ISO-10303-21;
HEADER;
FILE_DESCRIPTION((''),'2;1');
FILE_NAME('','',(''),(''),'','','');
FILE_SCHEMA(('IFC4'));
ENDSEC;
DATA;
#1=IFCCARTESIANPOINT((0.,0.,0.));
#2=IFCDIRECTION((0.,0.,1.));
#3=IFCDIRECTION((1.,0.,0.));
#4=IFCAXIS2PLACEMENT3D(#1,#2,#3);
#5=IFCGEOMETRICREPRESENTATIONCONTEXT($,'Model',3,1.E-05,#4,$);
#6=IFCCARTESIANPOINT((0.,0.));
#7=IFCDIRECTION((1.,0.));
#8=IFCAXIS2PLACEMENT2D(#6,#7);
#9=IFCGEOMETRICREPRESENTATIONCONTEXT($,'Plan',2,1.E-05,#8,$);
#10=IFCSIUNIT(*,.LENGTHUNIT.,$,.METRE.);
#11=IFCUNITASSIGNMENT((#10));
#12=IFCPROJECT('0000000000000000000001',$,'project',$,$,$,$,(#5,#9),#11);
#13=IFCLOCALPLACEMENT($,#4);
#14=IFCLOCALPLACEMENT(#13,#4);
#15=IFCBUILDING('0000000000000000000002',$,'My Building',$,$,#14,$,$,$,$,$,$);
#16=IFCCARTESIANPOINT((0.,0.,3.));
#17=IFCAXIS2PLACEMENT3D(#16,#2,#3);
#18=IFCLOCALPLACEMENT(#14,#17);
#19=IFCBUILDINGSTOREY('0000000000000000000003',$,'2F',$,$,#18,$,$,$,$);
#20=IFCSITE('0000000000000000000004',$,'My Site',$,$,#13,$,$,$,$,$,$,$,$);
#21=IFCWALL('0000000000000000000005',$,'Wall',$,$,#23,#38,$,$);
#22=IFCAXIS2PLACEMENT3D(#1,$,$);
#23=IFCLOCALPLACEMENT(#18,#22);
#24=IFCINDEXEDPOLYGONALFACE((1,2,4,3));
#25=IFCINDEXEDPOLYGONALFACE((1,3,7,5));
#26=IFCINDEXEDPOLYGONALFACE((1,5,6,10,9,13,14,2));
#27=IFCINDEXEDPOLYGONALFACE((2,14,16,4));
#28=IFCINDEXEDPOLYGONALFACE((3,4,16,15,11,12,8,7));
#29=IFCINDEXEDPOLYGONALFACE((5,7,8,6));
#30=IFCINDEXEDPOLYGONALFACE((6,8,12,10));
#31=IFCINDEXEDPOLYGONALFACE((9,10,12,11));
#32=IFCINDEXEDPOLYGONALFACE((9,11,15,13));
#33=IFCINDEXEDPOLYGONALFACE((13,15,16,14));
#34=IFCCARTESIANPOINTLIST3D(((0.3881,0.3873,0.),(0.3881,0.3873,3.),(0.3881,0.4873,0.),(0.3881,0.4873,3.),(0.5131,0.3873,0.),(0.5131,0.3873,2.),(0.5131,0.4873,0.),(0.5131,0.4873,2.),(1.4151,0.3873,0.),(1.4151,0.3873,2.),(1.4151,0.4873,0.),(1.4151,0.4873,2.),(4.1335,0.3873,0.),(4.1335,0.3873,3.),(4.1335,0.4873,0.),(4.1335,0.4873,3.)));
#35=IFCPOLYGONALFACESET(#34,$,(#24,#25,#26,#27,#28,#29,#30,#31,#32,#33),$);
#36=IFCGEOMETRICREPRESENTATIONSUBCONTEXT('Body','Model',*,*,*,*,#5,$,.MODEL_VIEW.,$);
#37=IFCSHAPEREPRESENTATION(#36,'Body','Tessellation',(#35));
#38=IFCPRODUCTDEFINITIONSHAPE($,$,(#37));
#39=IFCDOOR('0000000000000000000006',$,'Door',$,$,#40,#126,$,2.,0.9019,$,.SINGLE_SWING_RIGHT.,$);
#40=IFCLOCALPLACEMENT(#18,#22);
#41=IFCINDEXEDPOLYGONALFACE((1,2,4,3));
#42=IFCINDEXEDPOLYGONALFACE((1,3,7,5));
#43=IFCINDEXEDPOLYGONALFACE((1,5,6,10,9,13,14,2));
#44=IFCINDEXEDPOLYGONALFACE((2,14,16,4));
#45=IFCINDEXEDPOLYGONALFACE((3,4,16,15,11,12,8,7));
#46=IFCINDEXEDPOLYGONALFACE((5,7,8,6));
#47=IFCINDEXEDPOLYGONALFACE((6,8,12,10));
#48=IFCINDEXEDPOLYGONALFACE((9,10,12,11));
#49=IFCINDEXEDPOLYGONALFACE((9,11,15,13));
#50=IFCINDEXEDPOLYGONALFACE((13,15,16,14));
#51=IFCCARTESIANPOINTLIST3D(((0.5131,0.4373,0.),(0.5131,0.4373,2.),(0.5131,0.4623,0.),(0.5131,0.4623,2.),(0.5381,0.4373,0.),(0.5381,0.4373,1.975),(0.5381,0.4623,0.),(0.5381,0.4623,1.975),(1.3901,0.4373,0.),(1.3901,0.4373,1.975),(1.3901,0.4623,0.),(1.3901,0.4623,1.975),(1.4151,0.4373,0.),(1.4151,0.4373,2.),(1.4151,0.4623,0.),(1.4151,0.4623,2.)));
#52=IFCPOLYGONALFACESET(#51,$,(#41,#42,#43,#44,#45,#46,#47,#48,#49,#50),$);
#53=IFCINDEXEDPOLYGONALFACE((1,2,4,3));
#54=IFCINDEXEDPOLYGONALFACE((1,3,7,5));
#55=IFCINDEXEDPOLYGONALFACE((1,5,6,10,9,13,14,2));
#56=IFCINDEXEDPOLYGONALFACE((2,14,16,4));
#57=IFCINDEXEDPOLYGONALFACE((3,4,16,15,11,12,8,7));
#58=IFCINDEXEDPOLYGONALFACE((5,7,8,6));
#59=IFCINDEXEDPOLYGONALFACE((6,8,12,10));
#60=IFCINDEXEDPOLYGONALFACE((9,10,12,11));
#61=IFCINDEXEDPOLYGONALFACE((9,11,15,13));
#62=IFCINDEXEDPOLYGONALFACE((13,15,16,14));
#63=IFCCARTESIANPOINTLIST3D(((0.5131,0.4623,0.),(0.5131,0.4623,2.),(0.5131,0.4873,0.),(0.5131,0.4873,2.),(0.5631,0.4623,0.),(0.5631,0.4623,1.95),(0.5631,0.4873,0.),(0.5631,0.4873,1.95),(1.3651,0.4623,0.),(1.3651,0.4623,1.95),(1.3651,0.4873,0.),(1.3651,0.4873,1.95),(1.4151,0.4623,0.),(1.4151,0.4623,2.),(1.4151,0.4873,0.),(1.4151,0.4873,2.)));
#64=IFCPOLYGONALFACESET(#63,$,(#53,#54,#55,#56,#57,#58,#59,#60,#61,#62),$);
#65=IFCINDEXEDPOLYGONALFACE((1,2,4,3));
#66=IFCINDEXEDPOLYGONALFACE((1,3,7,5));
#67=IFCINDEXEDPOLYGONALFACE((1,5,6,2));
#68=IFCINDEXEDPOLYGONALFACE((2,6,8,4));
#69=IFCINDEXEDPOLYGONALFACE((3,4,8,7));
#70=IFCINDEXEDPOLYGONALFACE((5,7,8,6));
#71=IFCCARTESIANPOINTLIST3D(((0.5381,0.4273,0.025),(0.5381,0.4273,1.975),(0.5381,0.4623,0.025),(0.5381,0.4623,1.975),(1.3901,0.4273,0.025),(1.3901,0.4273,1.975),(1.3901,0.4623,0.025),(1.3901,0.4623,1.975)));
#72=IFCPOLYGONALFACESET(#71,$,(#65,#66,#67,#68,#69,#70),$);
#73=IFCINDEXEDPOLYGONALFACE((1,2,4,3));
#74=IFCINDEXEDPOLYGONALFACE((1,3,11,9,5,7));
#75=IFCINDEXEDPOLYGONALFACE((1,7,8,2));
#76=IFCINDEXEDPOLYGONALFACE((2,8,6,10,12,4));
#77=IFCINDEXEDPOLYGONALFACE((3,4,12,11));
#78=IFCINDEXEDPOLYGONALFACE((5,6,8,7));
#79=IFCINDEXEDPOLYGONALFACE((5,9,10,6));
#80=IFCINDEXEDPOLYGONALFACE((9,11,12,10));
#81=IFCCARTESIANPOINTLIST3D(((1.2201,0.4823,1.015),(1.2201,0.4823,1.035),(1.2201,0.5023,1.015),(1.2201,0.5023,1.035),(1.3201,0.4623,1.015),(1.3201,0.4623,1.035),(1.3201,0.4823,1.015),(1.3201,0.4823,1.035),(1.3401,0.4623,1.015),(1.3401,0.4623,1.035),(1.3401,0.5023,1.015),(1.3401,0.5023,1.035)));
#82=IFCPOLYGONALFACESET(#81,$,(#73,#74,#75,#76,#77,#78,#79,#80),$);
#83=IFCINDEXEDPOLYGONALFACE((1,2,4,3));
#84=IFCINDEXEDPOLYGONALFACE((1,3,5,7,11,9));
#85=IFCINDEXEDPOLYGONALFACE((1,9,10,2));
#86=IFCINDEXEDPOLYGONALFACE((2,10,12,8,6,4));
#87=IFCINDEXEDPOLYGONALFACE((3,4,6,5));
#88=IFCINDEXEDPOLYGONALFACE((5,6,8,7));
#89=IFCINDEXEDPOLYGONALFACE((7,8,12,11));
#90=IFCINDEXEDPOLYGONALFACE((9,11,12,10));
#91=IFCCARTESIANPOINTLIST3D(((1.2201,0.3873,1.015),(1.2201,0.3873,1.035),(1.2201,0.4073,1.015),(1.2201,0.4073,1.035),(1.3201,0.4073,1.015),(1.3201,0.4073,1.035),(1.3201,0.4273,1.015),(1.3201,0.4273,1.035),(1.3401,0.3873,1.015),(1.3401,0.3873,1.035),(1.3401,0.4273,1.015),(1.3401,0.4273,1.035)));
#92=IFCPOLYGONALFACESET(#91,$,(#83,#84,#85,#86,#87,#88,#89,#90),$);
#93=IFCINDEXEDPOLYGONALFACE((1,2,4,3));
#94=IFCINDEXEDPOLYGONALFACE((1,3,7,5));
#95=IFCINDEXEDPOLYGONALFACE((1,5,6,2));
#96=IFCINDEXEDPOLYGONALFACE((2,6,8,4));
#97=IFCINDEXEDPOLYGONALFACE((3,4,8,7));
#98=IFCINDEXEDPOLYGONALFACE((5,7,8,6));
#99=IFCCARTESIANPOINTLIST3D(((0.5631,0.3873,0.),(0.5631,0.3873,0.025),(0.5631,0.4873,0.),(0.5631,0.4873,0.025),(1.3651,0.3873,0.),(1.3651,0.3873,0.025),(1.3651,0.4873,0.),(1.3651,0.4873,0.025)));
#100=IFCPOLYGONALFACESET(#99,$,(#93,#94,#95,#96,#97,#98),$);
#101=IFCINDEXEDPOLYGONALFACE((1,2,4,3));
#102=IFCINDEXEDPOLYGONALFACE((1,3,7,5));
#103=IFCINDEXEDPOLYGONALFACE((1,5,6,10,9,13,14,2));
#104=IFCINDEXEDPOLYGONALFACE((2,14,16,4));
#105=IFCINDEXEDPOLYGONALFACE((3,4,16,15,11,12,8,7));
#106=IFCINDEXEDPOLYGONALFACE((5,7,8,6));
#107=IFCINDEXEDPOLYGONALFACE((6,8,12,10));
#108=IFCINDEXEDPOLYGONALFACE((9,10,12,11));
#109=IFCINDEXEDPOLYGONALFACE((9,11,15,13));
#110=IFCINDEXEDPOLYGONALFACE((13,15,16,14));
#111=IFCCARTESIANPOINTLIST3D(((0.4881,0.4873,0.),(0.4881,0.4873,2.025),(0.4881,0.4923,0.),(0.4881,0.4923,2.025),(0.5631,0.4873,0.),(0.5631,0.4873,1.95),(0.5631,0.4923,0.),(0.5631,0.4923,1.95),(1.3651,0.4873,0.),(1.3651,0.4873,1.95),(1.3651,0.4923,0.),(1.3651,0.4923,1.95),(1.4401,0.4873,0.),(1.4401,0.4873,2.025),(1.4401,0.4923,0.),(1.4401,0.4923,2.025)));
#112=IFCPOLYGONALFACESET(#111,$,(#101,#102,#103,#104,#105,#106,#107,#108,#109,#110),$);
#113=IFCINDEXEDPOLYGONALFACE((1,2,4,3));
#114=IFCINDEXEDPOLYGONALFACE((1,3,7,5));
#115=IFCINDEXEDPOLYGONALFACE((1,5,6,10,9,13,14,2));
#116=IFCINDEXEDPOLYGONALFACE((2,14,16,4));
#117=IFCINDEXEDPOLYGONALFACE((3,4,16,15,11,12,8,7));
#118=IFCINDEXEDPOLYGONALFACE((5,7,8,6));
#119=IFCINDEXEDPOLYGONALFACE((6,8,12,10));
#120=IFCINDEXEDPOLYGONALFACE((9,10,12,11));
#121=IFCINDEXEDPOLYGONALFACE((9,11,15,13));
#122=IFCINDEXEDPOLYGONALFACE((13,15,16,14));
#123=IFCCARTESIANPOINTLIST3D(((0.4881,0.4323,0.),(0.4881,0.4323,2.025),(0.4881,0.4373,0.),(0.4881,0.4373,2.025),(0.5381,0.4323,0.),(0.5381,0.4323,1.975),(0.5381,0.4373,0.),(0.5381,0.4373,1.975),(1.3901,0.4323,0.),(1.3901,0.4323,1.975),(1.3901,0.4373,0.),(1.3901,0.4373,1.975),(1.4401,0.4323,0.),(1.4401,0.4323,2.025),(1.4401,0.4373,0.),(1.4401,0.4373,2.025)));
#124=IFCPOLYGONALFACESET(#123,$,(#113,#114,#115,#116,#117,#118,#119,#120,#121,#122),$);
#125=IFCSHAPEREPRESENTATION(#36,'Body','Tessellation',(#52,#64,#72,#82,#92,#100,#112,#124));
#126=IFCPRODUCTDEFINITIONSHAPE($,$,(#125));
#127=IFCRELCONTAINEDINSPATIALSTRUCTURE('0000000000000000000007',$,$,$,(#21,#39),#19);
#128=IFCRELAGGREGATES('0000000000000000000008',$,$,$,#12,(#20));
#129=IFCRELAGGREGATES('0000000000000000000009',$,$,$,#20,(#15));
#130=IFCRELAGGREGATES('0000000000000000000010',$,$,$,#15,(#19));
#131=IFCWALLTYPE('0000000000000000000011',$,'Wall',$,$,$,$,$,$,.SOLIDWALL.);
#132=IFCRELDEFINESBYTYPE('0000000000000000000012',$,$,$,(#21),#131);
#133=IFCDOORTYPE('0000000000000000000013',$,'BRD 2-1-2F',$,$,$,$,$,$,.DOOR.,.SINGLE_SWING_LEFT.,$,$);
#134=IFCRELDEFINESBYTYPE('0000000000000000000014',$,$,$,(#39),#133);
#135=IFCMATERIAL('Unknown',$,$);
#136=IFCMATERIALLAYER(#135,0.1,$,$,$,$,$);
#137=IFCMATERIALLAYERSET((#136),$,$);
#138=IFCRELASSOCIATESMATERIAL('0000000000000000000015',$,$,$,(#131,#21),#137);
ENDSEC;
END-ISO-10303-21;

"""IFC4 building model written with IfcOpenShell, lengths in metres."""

from ifc_helpers import new_model, entity, si_unit, frame, origin_with_axes, origin_2d_with_axis, place, context, subcontext, project, spatial, line, indexed_curve, outline, extrude, shape, source, transform, mapped, material, layer, layer_set, layer_usage, type_object, type_shapes, element, fill, save


model = new_model("IFC4")

# Units and contexts
model_context = context("Model", 3, precision=1e-05, world=origin_with_axes())
plan_context = context("Plan", 2, precision=1e-05, world=origin_2d_with_axis())
body_context_1 = subcontext(model_context, "Body", "Model", "MODEL_VIEW")
body_context_2 = subcontext(plan_context, "Body", "Plan", "PLAN_VIEW")
ifc_project = project(units=[si_unit("LENGTHUNIT", "METRE")], contexts=[model_context, plan_context])

# Site, building, storey
site_placement = place(None, origin_with_axes())
site = spatial("IfcSite", under=ifc_project, at=site_placement, Name="My Site")
building_placement = place(site_placement, origin_with_axes())
building = spatial("IfcBuilding", under=site, at=building_placement, Name="My Building")
storey_placement = place(building_placement, frame((0.0, 0.0, 3.0), z_axis=(0.0, 0.0, 1.0), x_axis=(1.0, 0.0, 0.0)))
storey = spatial("IfcBuildingStorey", under=building, at=storey_placement, Name="2F")

# Shared definitions
ifc_material = material(Name="Unknown")
ifc_layer = layer(ifc_material, 0.1)
ifc_layer_set = layer_set([ifc_layer])
wall_type = type_object("IfcWallType", Name="Wall", PredefinedType="SOLIDWALL", material=ifc_layer_set)

# Wall, opening, door
ifc_layer_usage_1 = layer_usage(ifc_layer_set, "AXIS2", "POSITIVE", 0.0)
wall_1_placement = place(storey_placement, frame((0.3881, 0.3873, 0.0), z_axis=(0.0, 0.0, 1.0), x_axis=(1.0, 0.0, 0.0)))
wall_1 = element("IfcWall", 1, at=wall_1_placement, inside=storey, type_object=wall_type, material=ifc_layer_usage_1, Name="Wall", context=body_context_1, shape_type="SweptSolid", body=[
    extrude(outline(indexed_curve([(0.0, 0.0), (0.0, 0.1), (3.7454, 0.1), (3.7454, 0.0)], segments=[line(1, 2, 3, 4, 1)])), origin_with_axes(), (0.0, 0.0, 1.0), 3.0),
])
shared_shape_1 = source(origin_with_axes(), body_context_1, "Body", "SweptSolid", [
    extrude(outline(indexed_curve([(0.0, 0.0), (0.9019, 0.0), (0.9019, 2.0), (0.0, 2.0)], segments=[line(1, 2, 3, 4, 1)])), frame((0.0, -0.6, 0.0), z_axis=(0.0, -1.0, 0.0), x_axis=(1.0, 0.0, 0.0)), (0.0, 0.0, -1.0), 1.2),
])
opening_1_placement = place(wall_1_placement, frame((1.0269, 0.1, 0.0), z_axis=(0.0, 0.0, 1.0), x_axis=(-1.0, 0.000001, 0.0)))
opening_1 = element("IfcOpeningElement", 2, at=opening_1_placement, cuts=wall_1, PredefinedType="OPENING", context=body_context_1, shape_type="MappedRepresentation", body=[
    mapped(shared_shape_1, transform((0.0, 0.0, 0.0), x_axis=(1.0, 0.0, 0.0), y_axis=(0.0, 1.0, 0.0), z_axis=(0.0, 0.0, 1.0), scale=1.0)),
])
door_type_1 = type_object("IfcDoorType", Name="BRD 2-1-2F", OperationType="SINGLE_SWING_LEFT", PredefinedType="DOOR")
shared_shape_2 = source(origin_with_axes(), body_context_1, "Body", "SweptSolid", [
    extrude(outline(indexed_curve([(0.0, 0.0), (0.0, 2.0), (0.9019, 2.0), (0.9019, 0.0), (0.8769, 0.0), (0.8769, 1.975), (0.025, 1.975), (0.025, 0.0)], segments=[line(1, 2, 3, 4, 5, 6, 7, 8, 1)])), frame((0.0, 0.025, 0.0), z_axis=(0.0, -1.0, 0.0), x_axis=(1.0, 0.0, 0.0)), (0.0, 0.0, -1.0), 0.025),
    extrude(outline(indexed_curve([(0.0, 0.0), (0.0, 2.0), (0.9019, 2.0), (0.9019, 0.0), (0.8519, 0.0), (0.8519, 1.95), (0.05, 1.95), (0.05, 0.0)], segments=[line(1, 2, 3, 4, 5, 6, 7, 8, 1)])), frame((0.0, 0.0, 0.0), z_axis=(0.0, -1.0, 0.0), x_axis=(1.0, 0.0, 0.0)), (0.0, 0.0, -1.0), 0.025),
    extrude(outline(indexed_curve([(0.0, 0.0), (0.8519, 0.0), (0.8519, 0.035), (0.0, 0.035)], segments=[line(1, 2, 3, 4, 1)])), frame((0.025, 0.025, 0.025), z_axis=(0.0, 0.0, 1.0), x_axis=(1.0, 0.0, 0.0)), (0.0, 0.0, 1.0), 1.95),
    extrude(outline(indexed_curve([(0.0, 0.0), (0.0, -0.04), (0.12, -0.04), (0.12, -0.02), (0.02, -0.02), (0.02, 0.0)], segments=[line(1, 2, 3, 4, 5, 6, 1)])), frame((0.075, 0.025, 1.015), z_axis=(0.0, 0.0, 1.0), x_axis=(1.0, 0.0, 0.0)), (0.0, 0.0, 1.0), 0.02),
    extrude(outline(indexed_curve([(0.0, 0.0), (0.0, 0.04), (0.12, 0.04), (0.12, 0.02), (0.02, 0.02), (0.02, 0.0)], segments=[line(1, 2, 3, 4, 5, 6, 1)])), frame((0.075, 0.06, 1.015), z_axis=(0.0, 0.0, 1.0), x_axis=(1.0, 0.0, 0.0)), (0.0, 0.0, 1.0), 0.02),
    extrude(outline(indexed_curve([(0.0, 0.0), (0.8019, 0.0), (0.8019, 0.1), (0.0, 0.1)], segments=[line(1, 2, 3, 4, 1)])), frame((0.05, 0.0, 0.0), z_axis=(0.0, 0.0, 1.0), x_axis=(1.0, 0.0, 0.0)), (0.0, 0.0, 1.0), 0.025),
    extrude(outline(indexed_curve([(0.0, 0.0), (0.0, 2.025), (0.9519, 2.025), (0.9519, 0.0), (0.8769, 0.0), (0.8769, 1.95), (0.075, 1.95), (0.075, 0.0)], segments=[line(1, 2, 3, 4, 5, 6, 7, 8, 1)])), frame((-0.025, -0.005, 0.0), z_axis=(0.0, -1.0, 0.0), x_axis=(1.0, 0.0, 0.0)), (0.0, 0.0, -1.0), 0.005),
    extrude(outline(indexed_curve([(0.0, 0.0), (0.0, 2.025), (0.9519, 2.025), (0.9519, 0.0), (0.9019, 0.0), (0.9019, 1.975), (0.05, 1.975), (0.05, 0.0)], segments=[line(1, 2, 3, 4, 5, 6, 7, 8, 1)])), frame((-0.025, 0.05, 0.0), z_axis=(0.0, -1.0, 0.0), x_axis=(1.0, 0.0, 0.0)), (0.0, 0.0, -1.0), 0.005),
])
shared_shape_3 = source(origin_with_axes(), body_context_2, "Body", "Curve2D", [
    entity("IfcIndexedPolyCurve", entity("IfcCartesianPointList2D", [[0.0, 0.0], [0.0, 0.05], [0.025, 0.05], [0.025, 0.025], [0.05, 0.025], [0.05, 0.0]]), [entity("IfcLineIndex", [1, 2, 3, 4, 5, 6, 1])]),
    entity("IfcIndexedPolyCurve", entity("IfcCartesianPointList2D", [[0.9019, 0.0], [0.9019, 0.05], [0.8769, 0.05], [0.8769, 0.025], [0.8519, 0.025], [0.8519, 0.0]]), [entity("IfcLineIndex", [1, 2, 3, 4, 5, 6, 1])]),
    entity("IfcTrimmedCurve", entity("IfcEllipse", entity("IfcAxis2Placement2D", entity("IfcCartesianPoint", [0.8419, 0.05]), entity("IfcDirection", [1.0, 0.0])), 0.8169, 0.8519), [entity("IfcCartesianPoint", [0.8419, 0.9019])], [entity("IfcCartesianPoint", [0.025, 0.05])], True, "CARTESIAN"),
    entity("IfcIndexedPolyCurve", entity("IfcCartesianPointList2D", [[0.8769, 0.05], [0.8419, 0.05], [0.8419, 0.9019], [0.8769, 0.9019]]), [entity("IfcLineIndex", [1, 2, 3, 4, 1])]),
])
type_shapes(door_type_1, [shared_shape_2, shared_shape_3])
door_1_placement = place(opening_1_placement, frame((0.0, 0.0, 0.0), z_axis=(0.0, 0.0, 1.0), x_axis=(1.0, 0.0, 0.0)))
door_1 = element("IfcDoor", 3, at=door_1_placement, inside=storey, type_object=door_type_1, Name="Door", OperationType="SINGLE_SWING_RIGHT", OverallHeight=2.0, OverallWidth=0.9019, shapes=[
    shape(body_context_1, "Body", "MappedRepresentation", [mapped(shared_shape_2, transform((0.0, 0.0, 0.0), x_axis=(1.0, 0.0, 0.0), y_axis=(0.0, 1.0, 0.0), z_axis=(0.0, 0.0, 1.0), scale=1.0))]),
    shape(body_context_2, "Body", "MappedRepresentation", [mapped(shared_shape_3, transform((0.0, 0.0, 0.0), x_axis=(1.0, 0.0, 0.0), y_axis=(0.0, 1.0, 0.0), z_axis=(0.0, 0.0, 1.0), scale=1.0))]),
])
fill(opening_1, door_1)

save(model, "model.ifc")
